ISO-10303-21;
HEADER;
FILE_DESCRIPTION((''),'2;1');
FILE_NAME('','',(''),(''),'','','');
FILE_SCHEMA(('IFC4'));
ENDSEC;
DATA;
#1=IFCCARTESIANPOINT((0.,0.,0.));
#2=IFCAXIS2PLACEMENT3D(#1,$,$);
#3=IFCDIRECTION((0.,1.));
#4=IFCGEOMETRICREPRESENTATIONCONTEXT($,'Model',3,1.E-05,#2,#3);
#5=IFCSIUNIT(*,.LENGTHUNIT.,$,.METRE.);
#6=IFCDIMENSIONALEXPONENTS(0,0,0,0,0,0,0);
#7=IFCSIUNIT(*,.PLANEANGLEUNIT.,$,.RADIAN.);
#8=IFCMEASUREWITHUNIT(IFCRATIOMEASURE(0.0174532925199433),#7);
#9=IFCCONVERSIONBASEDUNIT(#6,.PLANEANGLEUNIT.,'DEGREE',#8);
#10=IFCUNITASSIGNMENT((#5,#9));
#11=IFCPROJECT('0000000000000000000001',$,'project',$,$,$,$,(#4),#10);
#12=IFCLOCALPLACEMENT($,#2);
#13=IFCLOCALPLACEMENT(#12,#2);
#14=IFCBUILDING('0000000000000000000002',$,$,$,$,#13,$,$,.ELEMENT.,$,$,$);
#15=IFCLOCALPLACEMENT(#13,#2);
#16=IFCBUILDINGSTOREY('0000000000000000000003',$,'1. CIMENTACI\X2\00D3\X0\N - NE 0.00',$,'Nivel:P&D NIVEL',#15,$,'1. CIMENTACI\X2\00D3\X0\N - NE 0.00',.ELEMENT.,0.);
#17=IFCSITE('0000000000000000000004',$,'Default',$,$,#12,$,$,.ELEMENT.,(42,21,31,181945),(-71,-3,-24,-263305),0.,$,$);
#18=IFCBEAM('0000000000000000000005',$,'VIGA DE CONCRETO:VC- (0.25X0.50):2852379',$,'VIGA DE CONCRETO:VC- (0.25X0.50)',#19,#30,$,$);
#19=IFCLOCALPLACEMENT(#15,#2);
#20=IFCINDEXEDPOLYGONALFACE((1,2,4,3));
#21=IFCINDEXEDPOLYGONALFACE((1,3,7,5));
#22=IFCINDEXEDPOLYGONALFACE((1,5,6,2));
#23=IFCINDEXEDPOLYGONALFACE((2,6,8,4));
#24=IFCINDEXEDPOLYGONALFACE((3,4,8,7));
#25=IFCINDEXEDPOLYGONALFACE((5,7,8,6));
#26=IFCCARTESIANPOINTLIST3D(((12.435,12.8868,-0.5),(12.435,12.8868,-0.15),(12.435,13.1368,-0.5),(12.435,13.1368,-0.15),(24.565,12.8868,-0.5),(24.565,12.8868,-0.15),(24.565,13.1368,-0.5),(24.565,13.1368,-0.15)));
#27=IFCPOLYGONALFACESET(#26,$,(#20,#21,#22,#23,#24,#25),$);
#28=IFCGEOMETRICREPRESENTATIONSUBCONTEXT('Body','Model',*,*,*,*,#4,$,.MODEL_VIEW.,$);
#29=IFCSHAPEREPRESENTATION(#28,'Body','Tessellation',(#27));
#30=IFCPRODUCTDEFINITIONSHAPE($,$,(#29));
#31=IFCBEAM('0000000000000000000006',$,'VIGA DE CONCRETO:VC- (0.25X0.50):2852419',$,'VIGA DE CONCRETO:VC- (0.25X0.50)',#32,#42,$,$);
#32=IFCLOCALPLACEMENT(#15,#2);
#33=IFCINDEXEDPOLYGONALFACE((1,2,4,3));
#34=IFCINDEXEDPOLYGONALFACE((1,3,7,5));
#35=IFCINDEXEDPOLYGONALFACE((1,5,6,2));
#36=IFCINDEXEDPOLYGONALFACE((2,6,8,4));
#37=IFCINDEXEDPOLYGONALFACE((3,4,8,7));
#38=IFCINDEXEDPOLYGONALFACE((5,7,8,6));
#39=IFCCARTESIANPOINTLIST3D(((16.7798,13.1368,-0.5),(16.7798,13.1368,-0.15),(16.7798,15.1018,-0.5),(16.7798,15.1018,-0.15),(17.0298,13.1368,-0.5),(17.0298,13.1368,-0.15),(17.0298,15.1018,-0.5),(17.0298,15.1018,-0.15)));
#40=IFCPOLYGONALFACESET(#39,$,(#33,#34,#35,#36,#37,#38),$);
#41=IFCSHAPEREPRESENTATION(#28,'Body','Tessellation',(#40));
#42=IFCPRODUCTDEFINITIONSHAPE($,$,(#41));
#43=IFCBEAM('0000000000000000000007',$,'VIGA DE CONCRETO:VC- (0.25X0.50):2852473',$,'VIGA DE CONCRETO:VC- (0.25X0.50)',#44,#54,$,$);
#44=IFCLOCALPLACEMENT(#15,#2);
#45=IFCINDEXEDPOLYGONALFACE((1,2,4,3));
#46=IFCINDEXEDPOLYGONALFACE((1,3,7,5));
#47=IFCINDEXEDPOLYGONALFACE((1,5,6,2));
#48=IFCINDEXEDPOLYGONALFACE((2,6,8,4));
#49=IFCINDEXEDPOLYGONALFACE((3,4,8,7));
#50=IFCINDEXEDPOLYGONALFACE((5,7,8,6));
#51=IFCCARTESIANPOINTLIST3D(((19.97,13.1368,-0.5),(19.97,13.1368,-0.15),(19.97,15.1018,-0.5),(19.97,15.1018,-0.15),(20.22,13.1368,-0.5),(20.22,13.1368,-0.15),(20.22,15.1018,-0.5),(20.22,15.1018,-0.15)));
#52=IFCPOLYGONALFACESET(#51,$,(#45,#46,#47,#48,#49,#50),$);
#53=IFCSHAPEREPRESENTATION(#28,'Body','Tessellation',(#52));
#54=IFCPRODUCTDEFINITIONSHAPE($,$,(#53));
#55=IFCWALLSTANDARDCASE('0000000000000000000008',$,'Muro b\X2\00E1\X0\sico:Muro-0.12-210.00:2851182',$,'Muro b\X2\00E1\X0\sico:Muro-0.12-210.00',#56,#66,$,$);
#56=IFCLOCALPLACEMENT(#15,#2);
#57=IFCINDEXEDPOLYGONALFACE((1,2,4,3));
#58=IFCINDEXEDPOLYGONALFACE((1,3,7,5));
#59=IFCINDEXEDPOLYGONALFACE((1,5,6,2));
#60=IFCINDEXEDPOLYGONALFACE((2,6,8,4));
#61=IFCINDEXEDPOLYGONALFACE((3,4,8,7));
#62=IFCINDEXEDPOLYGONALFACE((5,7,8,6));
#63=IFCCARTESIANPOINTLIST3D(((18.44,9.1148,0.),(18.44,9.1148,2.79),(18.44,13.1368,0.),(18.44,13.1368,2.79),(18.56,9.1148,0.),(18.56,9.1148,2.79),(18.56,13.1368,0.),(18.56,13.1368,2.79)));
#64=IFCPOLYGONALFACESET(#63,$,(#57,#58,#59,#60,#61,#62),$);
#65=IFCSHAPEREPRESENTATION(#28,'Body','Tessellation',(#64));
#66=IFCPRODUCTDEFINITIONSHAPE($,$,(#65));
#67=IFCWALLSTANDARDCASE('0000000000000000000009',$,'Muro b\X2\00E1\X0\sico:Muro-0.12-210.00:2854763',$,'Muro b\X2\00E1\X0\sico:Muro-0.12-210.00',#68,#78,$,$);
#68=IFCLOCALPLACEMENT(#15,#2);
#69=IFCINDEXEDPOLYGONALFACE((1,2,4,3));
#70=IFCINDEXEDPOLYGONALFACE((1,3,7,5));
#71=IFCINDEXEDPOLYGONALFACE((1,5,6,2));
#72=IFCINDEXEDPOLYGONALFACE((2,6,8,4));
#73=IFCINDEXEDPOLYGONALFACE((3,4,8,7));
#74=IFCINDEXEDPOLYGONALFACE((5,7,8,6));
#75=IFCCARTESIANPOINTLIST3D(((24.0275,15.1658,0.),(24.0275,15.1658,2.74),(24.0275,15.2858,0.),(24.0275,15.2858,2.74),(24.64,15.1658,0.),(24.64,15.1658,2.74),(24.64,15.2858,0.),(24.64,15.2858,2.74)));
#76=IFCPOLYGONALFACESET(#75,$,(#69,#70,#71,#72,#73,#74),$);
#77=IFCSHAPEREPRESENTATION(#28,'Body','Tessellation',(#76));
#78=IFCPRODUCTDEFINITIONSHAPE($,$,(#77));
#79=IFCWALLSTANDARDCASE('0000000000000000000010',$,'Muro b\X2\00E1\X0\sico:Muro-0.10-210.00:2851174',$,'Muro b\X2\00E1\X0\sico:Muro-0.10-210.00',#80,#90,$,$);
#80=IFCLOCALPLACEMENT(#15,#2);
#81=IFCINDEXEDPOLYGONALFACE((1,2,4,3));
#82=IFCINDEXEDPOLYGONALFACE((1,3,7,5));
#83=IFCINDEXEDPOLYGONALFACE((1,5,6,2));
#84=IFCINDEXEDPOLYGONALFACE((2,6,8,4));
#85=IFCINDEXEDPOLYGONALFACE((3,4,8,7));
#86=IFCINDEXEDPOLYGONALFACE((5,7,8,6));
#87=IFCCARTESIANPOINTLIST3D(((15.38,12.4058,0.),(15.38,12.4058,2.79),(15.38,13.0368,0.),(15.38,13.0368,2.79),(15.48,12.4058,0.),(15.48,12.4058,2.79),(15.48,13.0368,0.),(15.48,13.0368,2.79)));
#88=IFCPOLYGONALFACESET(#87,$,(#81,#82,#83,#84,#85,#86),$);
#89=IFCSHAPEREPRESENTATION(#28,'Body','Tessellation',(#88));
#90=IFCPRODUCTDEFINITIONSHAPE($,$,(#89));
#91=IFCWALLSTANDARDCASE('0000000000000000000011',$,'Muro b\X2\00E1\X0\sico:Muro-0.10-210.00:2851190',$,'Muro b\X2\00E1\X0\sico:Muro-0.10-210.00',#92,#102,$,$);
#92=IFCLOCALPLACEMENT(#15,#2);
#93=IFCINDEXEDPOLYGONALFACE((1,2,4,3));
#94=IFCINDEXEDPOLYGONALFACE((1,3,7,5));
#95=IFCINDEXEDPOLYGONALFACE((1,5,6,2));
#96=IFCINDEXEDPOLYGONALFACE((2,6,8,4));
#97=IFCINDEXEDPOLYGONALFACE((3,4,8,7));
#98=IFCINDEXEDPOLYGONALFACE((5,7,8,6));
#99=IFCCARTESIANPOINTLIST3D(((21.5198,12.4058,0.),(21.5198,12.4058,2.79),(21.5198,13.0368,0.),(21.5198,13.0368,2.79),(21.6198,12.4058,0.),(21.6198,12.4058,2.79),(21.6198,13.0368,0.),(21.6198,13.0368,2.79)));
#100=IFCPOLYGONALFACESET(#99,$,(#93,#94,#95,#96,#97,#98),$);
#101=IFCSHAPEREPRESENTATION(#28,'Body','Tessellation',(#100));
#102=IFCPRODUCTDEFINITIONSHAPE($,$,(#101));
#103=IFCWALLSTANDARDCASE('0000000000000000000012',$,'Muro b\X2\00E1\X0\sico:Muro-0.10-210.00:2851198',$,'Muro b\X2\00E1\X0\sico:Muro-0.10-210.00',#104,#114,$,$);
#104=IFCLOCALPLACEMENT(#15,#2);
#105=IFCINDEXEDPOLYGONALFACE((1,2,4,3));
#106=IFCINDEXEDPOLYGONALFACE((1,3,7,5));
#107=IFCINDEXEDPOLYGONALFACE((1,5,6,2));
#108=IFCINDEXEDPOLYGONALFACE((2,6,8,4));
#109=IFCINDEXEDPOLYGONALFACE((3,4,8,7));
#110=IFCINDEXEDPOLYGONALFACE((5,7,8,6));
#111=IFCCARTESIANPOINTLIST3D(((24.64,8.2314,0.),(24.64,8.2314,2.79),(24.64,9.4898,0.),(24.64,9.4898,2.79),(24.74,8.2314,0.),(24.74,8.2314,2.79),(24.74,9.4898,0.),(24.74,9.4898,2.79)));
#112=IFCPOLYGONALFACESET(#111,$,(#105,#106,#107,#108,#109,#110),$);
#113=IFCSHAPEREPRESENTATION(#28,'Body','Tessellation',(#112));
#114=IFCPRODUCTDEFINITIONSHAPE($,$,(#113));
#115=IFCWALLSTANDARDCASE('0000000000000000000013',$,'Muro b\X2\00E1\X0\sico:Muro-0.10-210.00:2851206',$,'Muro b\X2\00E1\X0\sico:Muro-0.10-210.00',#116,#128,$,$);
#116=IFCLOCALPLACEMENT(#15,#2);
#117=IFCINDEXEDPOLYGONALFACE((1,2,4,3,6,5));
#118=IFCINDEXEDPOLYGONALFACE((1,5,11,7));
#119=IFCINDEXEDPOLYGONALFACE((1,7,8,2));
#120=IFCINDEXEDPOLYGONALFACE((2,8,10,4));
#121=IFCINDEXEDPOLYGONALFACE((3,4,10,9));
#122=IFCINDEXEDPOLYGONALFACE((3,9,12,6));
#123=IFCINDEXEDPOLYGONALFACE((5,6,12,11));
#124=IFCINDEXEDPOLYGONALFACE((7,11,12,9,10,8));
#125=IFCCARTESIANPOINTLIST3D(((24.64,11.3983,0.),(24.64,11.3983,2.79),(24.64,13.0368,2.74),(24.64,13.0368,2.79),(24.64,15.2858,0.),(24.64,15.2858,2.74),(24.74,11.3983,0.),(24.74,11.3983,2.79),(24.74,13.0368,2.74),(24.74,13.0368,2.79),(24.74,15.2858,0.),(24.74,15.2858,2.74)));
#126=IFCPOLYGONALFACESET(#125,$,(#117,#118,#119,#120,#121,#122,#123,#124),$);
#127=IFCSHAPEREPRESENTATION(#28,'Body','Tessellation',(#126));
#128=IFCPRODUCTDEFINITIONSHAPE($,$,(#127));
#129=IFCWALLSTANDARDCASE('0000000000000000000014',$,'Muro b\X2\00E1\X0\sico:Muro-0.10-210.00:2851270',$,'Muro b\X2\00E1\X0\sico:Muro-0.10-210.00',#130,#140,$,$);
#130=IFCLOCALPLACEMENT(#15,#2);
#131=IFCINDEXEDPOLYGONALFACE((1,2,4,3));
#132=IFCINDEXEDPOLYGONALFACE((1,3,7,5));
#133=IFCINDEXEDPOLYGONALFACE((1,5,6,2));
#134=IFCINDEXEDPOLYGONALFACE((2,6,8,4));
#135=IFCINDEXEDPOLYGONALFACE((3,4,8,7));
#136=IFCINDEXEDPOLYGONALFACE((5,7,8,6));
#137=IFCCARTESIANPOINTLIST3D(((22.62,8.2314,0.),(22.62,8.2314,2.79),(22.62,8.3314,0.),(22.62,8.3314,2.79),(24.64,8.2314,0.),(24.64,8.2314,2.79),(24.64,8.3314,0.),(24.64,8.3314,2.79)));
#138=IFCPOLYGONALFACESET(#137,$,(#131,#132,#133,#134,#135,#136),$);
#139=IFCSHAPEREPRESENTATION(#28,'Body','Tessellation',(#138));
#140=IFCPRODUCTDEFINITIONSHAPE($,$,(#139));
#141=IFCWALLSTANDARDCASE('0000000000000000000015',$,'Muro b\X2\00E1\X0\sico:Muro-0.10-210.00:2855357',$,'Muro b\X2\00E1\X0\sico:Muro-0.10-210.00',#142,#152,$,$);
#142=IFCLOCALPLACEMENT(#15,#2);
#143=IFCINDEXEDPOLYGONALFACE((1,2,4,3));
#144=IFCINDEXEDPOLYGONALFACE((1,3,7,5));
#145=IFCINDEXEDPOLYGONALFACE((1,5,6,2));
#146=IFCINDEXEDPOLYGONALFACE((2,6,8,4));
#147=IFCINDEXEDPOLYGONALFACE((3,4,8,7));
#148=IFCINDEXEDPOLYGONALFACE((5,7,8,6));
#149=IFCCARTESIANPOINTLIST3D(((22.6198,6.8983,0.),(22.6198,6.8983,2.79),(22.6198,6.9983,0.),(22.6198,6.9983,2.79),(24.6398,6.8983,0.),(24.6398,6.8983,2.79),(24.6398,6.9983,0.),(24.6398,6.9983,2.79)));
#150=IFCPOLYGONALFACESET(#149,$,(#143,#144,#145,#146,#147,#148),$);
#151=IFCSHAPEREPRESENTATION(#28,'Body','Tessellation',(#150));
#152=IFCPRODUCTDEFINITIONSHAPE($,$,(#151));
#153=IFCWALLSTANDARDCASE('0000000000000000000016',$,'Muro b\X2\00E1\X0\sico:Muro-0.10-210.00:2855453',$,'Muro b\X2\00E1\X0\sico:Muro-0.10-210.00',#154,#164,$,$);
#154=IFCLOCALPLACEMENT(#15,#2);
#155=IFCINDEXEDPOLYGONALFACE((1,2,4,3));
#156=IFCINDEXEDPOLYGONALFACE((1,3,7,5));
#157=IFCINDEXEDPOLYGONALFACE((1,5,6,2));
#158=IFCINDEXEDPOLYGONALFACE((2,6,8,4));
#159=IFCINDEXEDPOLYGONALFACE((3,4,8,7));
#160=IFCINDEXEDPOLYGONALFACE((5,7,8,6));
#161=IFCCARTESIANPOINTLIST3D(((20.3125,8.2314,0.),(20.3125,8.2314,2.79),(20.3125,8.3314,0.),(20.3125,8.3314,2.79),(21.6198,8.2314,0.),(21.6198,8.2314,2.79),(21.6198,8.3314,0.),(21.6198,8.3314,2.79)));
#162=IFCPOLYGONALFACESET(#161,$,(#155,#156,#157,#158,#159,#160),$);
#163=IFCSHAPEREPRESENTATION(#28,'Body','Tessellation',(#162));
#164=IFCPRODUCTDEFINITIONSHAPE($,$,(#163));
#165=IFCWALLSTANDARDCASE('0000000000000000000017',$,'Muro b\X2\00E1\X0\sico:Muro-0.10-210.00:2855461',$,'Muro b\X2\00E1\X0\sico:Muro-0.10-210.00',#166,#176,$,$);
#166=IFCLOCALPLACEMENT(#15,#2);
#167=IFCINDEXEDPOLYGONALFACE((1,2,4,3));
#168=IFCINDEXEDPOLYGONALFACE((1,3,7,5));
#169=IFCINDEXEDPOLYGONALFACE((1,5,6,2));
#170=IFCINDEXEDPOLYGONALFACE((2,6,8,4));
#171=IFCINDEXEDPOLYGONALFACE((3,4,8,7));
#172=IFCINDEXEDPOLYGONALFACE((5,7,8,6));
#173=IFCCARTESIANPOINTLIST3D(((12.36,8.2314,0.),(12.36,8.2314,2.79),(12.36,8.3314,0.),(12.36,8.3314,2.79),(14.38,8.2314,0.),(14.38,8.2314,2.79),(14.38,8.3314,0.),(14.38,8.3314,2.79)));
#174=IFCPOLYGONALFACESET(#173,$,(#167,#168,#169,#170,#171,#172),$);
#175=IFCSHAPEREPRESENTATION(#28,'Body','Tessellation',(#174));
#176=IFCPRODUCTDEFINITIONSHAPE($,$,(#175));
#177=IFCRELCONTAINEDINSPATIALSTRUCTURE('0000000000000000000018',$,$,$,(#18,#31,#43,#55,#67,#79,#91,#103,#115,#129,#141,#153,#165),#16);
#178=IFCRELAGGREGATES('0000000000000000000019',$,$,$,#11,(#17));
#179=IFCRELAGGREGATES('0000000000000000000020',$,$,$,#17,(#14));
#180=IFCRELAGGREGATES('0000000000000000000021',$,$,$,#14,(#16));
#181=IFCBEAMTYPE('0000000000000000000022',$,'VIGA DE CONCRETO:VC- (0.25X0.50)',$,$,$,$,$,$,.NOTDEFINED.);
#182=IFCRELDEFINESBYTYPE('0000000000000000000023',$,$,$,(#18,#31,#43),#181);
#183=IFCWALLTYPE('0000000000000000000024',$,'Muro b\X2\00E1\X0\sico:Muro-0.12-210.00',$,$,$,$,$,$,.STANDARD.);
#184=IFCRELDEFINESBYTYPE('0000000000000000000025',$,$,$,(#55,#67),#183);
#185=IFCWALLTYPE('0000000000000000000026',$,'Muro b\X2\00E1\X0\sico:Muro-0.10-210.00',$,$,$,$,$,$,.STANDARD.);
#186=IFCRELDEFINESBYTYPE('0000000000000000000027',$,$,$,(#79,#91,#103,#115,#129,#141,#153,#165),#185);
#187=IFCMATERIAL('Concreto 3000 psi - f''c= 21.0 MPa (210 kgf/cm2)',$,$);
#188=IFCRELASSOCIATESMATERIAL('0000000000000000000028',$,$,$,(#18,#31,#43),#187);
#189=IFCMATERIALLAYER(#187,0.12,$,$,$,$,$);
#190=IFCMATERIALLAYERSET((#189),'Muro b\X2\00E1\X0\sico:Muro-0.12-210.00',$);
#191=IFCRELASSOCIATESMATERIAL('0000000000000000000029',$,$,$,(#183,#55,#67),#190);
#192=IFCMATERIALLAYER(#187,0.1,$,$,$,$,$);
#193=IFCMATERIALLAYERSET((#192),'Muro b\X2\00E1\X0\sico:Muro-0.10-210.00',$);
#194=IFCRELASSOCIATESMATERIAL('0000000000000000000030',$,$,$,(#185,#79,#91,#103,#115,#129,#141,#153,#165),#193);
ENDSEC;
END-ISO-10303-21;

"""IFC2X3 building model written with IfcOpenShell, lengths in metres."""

from ifc_helpers import new_model, entity, si_unit, converted_unit, direction, frame, frame_2d, origin, place, context, subcontext, project, spatial, polyline, rectangle, extrude, clip, bounded_halfspace, material, layer, layer_set, layer_usage, type_object, element, save


model = new_model("IFC2X3")

# Units and contexts
model_context = context("Model", 3, precision=1e-05, world=origin(), true_north=direction((0.0, 1.0)))
body_context = subcontext(model_context, "Body", "Model", "MODEL_VIEW")
ifc_project = project(units=[si_unit("LENGTHUNIT", "METRE"), converted_unit("PLANEANGLEUNIT", "DEGREE", entity("IfcRatioMeasure", 0.0174532925199433), si_unit("PLANEANGLEUNIT", "RADIAN"), dimensions=[0, 0, 0, 0, 0, 0, 0])], contexts=[model_context])

# Site, building, storey
site_placement = place(None, origin())
site = spatial("IfcSite", under=ifc_project, at=site_placement, Name="Default", CompositionType="ELEMENT", RefLatitude=(42, 21, 31, 181945), RefLongitude=(-71, -3, -24, -263305), RefElevation=0.0)
building_placement = place(site_placement, origin())
building = spatial("IfcBuilding", under=site, at=building_placement, CompositionType="ELEMENT")
storey_placement = place(building_placement, origin())
storey = spatial("IfcBuildingStorey", under=building, at=storey_placement, Name="1. CIMENTACIÓN - NE 0.00", ObjectType="Nivel:P&D NIVEL", LongName="1. CIMENTACIÓN - NE 0.00", CompositionType="ELEMENT", Elevation=0.0)

# Beams
ifc_material = material(Name="Concreto 3000 psi - f'c= 21.0 MPa (210 kgf/cm2)")
beam_type = type_object("IfcBeamType", Name="VIGA DE CONCRETO:VC- (0.25X0.50)", PredefinedType="NOTDEFINED")
beam_1_placement = place(storey_placement, frame((24.69, 13.0118, 0.0), z_axis=(0.0, 0.0, 1.0), x_axis=(-1.0, 0.0, 0.0)))
element("IfcBeam", 1, at=beam_1_placement, inside=storey, type_object=beam_type, material=ifc_material, Name="VIGA DE CONCRETO:VC- (0.25X0.50):2852379", ObjectType="VIGA DE CONCRETO:VC- (0.25X0.50)", context=body_context, shape_type="SweptSolid", body=[
    extrude(rectangle(XDim=0.35, YDim=0.25, at=frame_2d((0.0, 0.0), x_axis=(1.0, 0.0))), frame((0.125, 0.0, -0.325), z_axis=(1.0, 0.0, 0.0), x_axis=(0.0, 0.0, -1.0)), (0.0, 0.0, 1.0), 12.13),
])
beam_2_placement = place(storey_placement, frame((16.9048, 13.0118, 0.0), z_axis=(0.0, 0.0, 1.0), x_axis=(0.0, 1.0, 0.0)))
element("IfcBeam", 2, at=beam_2_placement, inside=storey, type_object=beam_type, material=ifc_material, Name="VIGA DE CONCRETO:VC- (0.25X0.50):2852419", ObjectType="VIGA DE CONCRETO:VC- (0.25X0.50)", context=body_context, shape_type="SweptSolid", body=[
    extrude(rectangle(XDim=0.35, YDim=0.25, at=frame_2d((0.0, 0.0), x_axis=(1.0, 0.0))), frame((0.125, 0.0, -0.325), z_axis=(1.0, 0.0, 0.0), x_axis=(0.0, 0.0, -1.0)), (0.0, 0.0, 1.0), 1.965),
])
beam_3_placement = place(storey_placement, frame((20.095, 13.0118, 0.0), z_axis=(0.0, 0.0, 1.0), x_axis=(0.0, 1.0, 0.0)))
element("IfcBeam", 3, at=beam_3_placement, inside=storey, type_object=beam_type, material=ifc_material, Name="VIGA DE CONCRETO:VC- (0.25X0.50):2852473", ObjectType="VIGA DE CONCRETO:VC- (0.25X0.50)", context=body_context, shape_type="SweptSolid", body=[
    extrude(rectangle(XDim=0.35, YDim=0.25, at=frame_2d((0.0, 0.0), x_axis=(1.0, 0.0))), frame((0.125, 0.0, -0.325), z_axis=(1.0, 0.0, 0.0), x_axis=(0.0, 0.0, -1.0)), (0.0, 0.0, 1.0), 1.965),
])

# Walls
ifc_layer_1 = layer(ifc_material, 0.12)
ifc_layer_set_1 = layer_set([ifc_layer_1], Name="Muro básico:Muro-0.12-210.00")
ifc_layer_usage_1 = layer_usage(ifc_layer_set_1, "AXIS2", "POSITIVE", -0.06)
wall_type_1 = type_object("IfcWallType", Name="Muro básico:Muro-0.12-210.00", PredefinedType="STANDARD", material=ifc_layer_set_1)
wall_1_placement = place(storey_placement, frame((18.5, 9.1148, 0.0), z_axis=(0.0, 0.0, 1.0), x_axis=(0.0, 1.0, 0.0)))
element("IfcWallStandardCase", 4, at=wall_1_placement, inside=storey, type_object=wall_type_1, material=ifc_layer_usage_1, Name="Muro básico:Muro-0.12-210.00:2851182", ObjectType="Muro básico:Muro-0.12-210.00", context=body_context, shape_type="SweptSolid", body=[
    extrude(rectangle(XDim=4.022, YDim=0.12, at=frame_2d((2.011, 0.0), x_axis=(-1.0, 0.0))), origin(), (0.0, 0.0, 1.0), 2.79),
])
wall_2_placement = place(storey_placement, frame((24.0275, 15.2258, 0.0)))
element("IfcWallStandardCase", 5, at=wall_2_placement, inside=storey, type_object=wall_type_1, material=ifc_layer_usage_1, Name="Muro básico:Muro-0.12-210.00:2854763", ObjectType="Muro básico:Muro-0.12-210.00", context=body_context, shape_type="SweptSolid", body=[
    extrude(rectangle(XDim=0.6125, YDim=0.12, at=frame_2d((0.3062, 0.0), x_axis=(-1.0, 0.0))), origin(), (0.0, 0.0, 1.0), 2.74),
])
ifc_layer_2 = layer(ifc_material, 0.1)
ifc_layer_set_2 = layer_set([ifc_layer_2], Name="Muro básico:Muro-0.10-210.00")
ifc_layer_usage_2 = layer_usage(ifc_layer_set_2, "AXIS2", "POSITIVE", -0.05)
wall_type_2 = type_object("IfcWallType", Name="Muro básico:Muro-0.10-210.00", PredefinedType="STANDARD", material=ifc_layer_set_2)
wall_3_placement = place(storey_placement, frame((15.43, 12.4058, 0.0), z_axis=(0.0, 0.0, 1.0), x_axis=(0.0, 1.0, 0.0)))
element("IfcWallStandardCase", 6, at=wall_3_placement, inside=storey, type_object=wall_type_2, material=ifc_layer_usage_2, Name="Muro básico:Muro-0.10-210.00:2851174", ObjectType="Muro básico:Muro-0.10-210.00", context=body_context, shape_type="SweptSolid", body=[
    extrude(rectangle(XDim=0.631, YDim=0.1, at=frame_2d((0.3155, 0.0), x_axis=(-1.0, 0.0))), origin(), (0.0, 0.0, 1.0), 2.79),
])
wall_4_placement = place(storey_placement, frame((21.5698, 12.4058, 0.0), z_axis=(0.0, 0.0, 1.0), x_axis=(0.0, 1.0, 0.0)))
element("IfcWallStandardCase", 7, at=wall_4_placement, inside=storey, type_object=wall_type_2, material=ifc_layer_usage_2, Name="Muro básico:Muro-0.10-210.00:2851190", ObjectType="Muro básico:Muro-0.10-210.00", context=body_context, shape_type="SweptSolid", body=[
    extrude(rectangle(XDim=0.631, YDim=0.1, at=frame_2d((0.3155, 0.0), x_axis=(-1.0, 0.0))), origin(), (0.0, 0.0, 1.0), 2.79),
])
wall_5_placement = place(storey_placement, frame((24.69, 8.2314, 0.0), z_axis=(0.0, 0.0, 1.0), x_axis=(0.0, 1.0, 0.0)))
element("IfcWallStandardCase", 8, at=wall_5_placement, inside=storey, type_object=wall_type_2, material=ifc_layer_usage_2, Name="Muro básico:Muro-0.10-210.00:2851198", ObjectType="Muro básico:Muro-0.10-210.00", context=body_context, shape_type="SweptSolid", body=[
    extrude(rectangle(XDim=1.2584, YDim=0.1, at=frame_2d((0.6292, 0.0), x_axis=(-1.0, 0.0))), origin(), (0.0, 0.0, 1.0), 2.79),
])
wall_6_placement = place(storey_placement, frame((24.69, 11.3983, 0.0), z_axis=(0.0, 0.0, 1.0), x_axis=(0.0, 1.0, 0.0)))
element("IfcWallStandardCase", 9, at=wall_6_placement, inside=storey, type_object=wall_type_2, material=ifc_layer_usage_2, Name="Muro básico:Muro-0.10-210.00:2851206", ObjectType="Muro básico:Muro-0.10-210.00", context=body_context, shape_type="Clipping", body=[
    clip(clip(extrude(rectangle(XDim=3.8875, YDim=0.1, at=frame_2d((1.9437, 0.0), x_axis=(-1.0, 0.0))), origin(), (0.0, 0.0, 1.0), 2.79), bounded_halfspace(frame((1.6385, 0.05, 2.74), z_axis=(0.0, 0.0, -1.0), x_axis=(0.0, -1.0, 0.0)), True, frame((1.6385, 0.05, 2.74), z_axis=(0.0, 0.0, -1.0), x_axis=(0.0, -1.0, 0.0)), polyline([(0.0, 0.0), (0.0, -2.129), (0.0, -2.249), (0.1, -2.249), (0.1, 0.0), (0.0, 0.0)]))), bounded_halfspace(frame((1.6385, -0.05, 2.74), z_axis=(-1.0, 0.0, 0.0), x_axis=(0.0, 0.0, 1.0)), True, frame((1.6385, -0.05, 2.74), z_axis=(-1.0, 0.0, 0.0), x_axis=(0.0, 0.0, 1.0)), polyline([(0.0, 0.0), (0.05, 0.0), (0.05, 0.1), (0.0, 0.1), (0.0, 0.0)]))),
])
wall_7_placement = place(storey_placement, frame((22.62, 8.2814, 0.0)))
element("IfcWallStandardCase", 10, at=wall_7_placement, inside=storey, type_object=wall_type_2, material=ifc_layer_usage_2, Name="Muro básico:Muro-0.10-210.00:2851270", ObjectType="Muro básico:Muro-0.10-210.00", context=body_context, shape_type="SweptSolid", body=[
    extrude(rectangle(XDim=2.02, YDim=0.1, at=frame_2d((1.01, 0.0), x_axis=(-1.0, 0.0))), origin(), (0.0, 0.0, 1.0), 2.79),
])
wall_8_placement = place(storey_placement, frame((22.6198, 6.9483, 0.0)))
element("IfcWallStandardCase", 11, at=wall_8_placement, inside=storey, type_object=wall_type_2, material=ifc_layer_usage_2, Name="Muro básico:Muro-0.10-210.00:2855357", ObjectType="Muro básico:Muro-0.10-210.00", context=body_context, shape_type="SweptSolid", body=[
    extrude(rectangle(XDim=2.02, YDim=0.1, at=frame_2d((1.01, 0.0), x_axis=(-1.0, 0.0))), origin(), (0.0, 0.0, 1.0), 2.79),
])
wall_9_placement = place(storey_placement, frame((20.3125, 8.2814, 0.0)))
element("IfcWallStandardCase", 12, at=wall_9_placement, inside=storey, type_object=wall_type_2, material=ifc_layer_usage_2, Name="Muro básico:Muro-0.10-210.00:2855453", ObjectType="Muro básico:Muro-0.10-210.00", context=body_context, shape_type="SweptSolid", body=[
    extrude(rectangle(XDim=1.3073, YDim=0.1, at=frame_2d((0.6536, 0.0), x_axis=(-1.0, 0.0))), origin(), (0.0, 0.0, 1.0), 2.79),
])
wall_10_placement = place(storey_placement, frame((12.36, 8.2814, 0.0)))
element("IfcWallStandardCase", 13, at=wall_10_placement, inside=storey, type_object=wall_type_2, material=ifc_layer_usage_2, Name="Muro básico:Muro-0.10-210.00:2855461", ObjectType="Muro básico:Muro-0.10-210.00", context=body_context, shape_type="SweptSolid", body=[
    extrude(rectangle(XDim=2.02, YDim=0.1, at=frame_2d((1.01, 0.0), x_axis=(-1.0, 0.0))), origin(), (0.0, 0.0, 1.0), 2.79),
])

save(model, "model.ifc")
